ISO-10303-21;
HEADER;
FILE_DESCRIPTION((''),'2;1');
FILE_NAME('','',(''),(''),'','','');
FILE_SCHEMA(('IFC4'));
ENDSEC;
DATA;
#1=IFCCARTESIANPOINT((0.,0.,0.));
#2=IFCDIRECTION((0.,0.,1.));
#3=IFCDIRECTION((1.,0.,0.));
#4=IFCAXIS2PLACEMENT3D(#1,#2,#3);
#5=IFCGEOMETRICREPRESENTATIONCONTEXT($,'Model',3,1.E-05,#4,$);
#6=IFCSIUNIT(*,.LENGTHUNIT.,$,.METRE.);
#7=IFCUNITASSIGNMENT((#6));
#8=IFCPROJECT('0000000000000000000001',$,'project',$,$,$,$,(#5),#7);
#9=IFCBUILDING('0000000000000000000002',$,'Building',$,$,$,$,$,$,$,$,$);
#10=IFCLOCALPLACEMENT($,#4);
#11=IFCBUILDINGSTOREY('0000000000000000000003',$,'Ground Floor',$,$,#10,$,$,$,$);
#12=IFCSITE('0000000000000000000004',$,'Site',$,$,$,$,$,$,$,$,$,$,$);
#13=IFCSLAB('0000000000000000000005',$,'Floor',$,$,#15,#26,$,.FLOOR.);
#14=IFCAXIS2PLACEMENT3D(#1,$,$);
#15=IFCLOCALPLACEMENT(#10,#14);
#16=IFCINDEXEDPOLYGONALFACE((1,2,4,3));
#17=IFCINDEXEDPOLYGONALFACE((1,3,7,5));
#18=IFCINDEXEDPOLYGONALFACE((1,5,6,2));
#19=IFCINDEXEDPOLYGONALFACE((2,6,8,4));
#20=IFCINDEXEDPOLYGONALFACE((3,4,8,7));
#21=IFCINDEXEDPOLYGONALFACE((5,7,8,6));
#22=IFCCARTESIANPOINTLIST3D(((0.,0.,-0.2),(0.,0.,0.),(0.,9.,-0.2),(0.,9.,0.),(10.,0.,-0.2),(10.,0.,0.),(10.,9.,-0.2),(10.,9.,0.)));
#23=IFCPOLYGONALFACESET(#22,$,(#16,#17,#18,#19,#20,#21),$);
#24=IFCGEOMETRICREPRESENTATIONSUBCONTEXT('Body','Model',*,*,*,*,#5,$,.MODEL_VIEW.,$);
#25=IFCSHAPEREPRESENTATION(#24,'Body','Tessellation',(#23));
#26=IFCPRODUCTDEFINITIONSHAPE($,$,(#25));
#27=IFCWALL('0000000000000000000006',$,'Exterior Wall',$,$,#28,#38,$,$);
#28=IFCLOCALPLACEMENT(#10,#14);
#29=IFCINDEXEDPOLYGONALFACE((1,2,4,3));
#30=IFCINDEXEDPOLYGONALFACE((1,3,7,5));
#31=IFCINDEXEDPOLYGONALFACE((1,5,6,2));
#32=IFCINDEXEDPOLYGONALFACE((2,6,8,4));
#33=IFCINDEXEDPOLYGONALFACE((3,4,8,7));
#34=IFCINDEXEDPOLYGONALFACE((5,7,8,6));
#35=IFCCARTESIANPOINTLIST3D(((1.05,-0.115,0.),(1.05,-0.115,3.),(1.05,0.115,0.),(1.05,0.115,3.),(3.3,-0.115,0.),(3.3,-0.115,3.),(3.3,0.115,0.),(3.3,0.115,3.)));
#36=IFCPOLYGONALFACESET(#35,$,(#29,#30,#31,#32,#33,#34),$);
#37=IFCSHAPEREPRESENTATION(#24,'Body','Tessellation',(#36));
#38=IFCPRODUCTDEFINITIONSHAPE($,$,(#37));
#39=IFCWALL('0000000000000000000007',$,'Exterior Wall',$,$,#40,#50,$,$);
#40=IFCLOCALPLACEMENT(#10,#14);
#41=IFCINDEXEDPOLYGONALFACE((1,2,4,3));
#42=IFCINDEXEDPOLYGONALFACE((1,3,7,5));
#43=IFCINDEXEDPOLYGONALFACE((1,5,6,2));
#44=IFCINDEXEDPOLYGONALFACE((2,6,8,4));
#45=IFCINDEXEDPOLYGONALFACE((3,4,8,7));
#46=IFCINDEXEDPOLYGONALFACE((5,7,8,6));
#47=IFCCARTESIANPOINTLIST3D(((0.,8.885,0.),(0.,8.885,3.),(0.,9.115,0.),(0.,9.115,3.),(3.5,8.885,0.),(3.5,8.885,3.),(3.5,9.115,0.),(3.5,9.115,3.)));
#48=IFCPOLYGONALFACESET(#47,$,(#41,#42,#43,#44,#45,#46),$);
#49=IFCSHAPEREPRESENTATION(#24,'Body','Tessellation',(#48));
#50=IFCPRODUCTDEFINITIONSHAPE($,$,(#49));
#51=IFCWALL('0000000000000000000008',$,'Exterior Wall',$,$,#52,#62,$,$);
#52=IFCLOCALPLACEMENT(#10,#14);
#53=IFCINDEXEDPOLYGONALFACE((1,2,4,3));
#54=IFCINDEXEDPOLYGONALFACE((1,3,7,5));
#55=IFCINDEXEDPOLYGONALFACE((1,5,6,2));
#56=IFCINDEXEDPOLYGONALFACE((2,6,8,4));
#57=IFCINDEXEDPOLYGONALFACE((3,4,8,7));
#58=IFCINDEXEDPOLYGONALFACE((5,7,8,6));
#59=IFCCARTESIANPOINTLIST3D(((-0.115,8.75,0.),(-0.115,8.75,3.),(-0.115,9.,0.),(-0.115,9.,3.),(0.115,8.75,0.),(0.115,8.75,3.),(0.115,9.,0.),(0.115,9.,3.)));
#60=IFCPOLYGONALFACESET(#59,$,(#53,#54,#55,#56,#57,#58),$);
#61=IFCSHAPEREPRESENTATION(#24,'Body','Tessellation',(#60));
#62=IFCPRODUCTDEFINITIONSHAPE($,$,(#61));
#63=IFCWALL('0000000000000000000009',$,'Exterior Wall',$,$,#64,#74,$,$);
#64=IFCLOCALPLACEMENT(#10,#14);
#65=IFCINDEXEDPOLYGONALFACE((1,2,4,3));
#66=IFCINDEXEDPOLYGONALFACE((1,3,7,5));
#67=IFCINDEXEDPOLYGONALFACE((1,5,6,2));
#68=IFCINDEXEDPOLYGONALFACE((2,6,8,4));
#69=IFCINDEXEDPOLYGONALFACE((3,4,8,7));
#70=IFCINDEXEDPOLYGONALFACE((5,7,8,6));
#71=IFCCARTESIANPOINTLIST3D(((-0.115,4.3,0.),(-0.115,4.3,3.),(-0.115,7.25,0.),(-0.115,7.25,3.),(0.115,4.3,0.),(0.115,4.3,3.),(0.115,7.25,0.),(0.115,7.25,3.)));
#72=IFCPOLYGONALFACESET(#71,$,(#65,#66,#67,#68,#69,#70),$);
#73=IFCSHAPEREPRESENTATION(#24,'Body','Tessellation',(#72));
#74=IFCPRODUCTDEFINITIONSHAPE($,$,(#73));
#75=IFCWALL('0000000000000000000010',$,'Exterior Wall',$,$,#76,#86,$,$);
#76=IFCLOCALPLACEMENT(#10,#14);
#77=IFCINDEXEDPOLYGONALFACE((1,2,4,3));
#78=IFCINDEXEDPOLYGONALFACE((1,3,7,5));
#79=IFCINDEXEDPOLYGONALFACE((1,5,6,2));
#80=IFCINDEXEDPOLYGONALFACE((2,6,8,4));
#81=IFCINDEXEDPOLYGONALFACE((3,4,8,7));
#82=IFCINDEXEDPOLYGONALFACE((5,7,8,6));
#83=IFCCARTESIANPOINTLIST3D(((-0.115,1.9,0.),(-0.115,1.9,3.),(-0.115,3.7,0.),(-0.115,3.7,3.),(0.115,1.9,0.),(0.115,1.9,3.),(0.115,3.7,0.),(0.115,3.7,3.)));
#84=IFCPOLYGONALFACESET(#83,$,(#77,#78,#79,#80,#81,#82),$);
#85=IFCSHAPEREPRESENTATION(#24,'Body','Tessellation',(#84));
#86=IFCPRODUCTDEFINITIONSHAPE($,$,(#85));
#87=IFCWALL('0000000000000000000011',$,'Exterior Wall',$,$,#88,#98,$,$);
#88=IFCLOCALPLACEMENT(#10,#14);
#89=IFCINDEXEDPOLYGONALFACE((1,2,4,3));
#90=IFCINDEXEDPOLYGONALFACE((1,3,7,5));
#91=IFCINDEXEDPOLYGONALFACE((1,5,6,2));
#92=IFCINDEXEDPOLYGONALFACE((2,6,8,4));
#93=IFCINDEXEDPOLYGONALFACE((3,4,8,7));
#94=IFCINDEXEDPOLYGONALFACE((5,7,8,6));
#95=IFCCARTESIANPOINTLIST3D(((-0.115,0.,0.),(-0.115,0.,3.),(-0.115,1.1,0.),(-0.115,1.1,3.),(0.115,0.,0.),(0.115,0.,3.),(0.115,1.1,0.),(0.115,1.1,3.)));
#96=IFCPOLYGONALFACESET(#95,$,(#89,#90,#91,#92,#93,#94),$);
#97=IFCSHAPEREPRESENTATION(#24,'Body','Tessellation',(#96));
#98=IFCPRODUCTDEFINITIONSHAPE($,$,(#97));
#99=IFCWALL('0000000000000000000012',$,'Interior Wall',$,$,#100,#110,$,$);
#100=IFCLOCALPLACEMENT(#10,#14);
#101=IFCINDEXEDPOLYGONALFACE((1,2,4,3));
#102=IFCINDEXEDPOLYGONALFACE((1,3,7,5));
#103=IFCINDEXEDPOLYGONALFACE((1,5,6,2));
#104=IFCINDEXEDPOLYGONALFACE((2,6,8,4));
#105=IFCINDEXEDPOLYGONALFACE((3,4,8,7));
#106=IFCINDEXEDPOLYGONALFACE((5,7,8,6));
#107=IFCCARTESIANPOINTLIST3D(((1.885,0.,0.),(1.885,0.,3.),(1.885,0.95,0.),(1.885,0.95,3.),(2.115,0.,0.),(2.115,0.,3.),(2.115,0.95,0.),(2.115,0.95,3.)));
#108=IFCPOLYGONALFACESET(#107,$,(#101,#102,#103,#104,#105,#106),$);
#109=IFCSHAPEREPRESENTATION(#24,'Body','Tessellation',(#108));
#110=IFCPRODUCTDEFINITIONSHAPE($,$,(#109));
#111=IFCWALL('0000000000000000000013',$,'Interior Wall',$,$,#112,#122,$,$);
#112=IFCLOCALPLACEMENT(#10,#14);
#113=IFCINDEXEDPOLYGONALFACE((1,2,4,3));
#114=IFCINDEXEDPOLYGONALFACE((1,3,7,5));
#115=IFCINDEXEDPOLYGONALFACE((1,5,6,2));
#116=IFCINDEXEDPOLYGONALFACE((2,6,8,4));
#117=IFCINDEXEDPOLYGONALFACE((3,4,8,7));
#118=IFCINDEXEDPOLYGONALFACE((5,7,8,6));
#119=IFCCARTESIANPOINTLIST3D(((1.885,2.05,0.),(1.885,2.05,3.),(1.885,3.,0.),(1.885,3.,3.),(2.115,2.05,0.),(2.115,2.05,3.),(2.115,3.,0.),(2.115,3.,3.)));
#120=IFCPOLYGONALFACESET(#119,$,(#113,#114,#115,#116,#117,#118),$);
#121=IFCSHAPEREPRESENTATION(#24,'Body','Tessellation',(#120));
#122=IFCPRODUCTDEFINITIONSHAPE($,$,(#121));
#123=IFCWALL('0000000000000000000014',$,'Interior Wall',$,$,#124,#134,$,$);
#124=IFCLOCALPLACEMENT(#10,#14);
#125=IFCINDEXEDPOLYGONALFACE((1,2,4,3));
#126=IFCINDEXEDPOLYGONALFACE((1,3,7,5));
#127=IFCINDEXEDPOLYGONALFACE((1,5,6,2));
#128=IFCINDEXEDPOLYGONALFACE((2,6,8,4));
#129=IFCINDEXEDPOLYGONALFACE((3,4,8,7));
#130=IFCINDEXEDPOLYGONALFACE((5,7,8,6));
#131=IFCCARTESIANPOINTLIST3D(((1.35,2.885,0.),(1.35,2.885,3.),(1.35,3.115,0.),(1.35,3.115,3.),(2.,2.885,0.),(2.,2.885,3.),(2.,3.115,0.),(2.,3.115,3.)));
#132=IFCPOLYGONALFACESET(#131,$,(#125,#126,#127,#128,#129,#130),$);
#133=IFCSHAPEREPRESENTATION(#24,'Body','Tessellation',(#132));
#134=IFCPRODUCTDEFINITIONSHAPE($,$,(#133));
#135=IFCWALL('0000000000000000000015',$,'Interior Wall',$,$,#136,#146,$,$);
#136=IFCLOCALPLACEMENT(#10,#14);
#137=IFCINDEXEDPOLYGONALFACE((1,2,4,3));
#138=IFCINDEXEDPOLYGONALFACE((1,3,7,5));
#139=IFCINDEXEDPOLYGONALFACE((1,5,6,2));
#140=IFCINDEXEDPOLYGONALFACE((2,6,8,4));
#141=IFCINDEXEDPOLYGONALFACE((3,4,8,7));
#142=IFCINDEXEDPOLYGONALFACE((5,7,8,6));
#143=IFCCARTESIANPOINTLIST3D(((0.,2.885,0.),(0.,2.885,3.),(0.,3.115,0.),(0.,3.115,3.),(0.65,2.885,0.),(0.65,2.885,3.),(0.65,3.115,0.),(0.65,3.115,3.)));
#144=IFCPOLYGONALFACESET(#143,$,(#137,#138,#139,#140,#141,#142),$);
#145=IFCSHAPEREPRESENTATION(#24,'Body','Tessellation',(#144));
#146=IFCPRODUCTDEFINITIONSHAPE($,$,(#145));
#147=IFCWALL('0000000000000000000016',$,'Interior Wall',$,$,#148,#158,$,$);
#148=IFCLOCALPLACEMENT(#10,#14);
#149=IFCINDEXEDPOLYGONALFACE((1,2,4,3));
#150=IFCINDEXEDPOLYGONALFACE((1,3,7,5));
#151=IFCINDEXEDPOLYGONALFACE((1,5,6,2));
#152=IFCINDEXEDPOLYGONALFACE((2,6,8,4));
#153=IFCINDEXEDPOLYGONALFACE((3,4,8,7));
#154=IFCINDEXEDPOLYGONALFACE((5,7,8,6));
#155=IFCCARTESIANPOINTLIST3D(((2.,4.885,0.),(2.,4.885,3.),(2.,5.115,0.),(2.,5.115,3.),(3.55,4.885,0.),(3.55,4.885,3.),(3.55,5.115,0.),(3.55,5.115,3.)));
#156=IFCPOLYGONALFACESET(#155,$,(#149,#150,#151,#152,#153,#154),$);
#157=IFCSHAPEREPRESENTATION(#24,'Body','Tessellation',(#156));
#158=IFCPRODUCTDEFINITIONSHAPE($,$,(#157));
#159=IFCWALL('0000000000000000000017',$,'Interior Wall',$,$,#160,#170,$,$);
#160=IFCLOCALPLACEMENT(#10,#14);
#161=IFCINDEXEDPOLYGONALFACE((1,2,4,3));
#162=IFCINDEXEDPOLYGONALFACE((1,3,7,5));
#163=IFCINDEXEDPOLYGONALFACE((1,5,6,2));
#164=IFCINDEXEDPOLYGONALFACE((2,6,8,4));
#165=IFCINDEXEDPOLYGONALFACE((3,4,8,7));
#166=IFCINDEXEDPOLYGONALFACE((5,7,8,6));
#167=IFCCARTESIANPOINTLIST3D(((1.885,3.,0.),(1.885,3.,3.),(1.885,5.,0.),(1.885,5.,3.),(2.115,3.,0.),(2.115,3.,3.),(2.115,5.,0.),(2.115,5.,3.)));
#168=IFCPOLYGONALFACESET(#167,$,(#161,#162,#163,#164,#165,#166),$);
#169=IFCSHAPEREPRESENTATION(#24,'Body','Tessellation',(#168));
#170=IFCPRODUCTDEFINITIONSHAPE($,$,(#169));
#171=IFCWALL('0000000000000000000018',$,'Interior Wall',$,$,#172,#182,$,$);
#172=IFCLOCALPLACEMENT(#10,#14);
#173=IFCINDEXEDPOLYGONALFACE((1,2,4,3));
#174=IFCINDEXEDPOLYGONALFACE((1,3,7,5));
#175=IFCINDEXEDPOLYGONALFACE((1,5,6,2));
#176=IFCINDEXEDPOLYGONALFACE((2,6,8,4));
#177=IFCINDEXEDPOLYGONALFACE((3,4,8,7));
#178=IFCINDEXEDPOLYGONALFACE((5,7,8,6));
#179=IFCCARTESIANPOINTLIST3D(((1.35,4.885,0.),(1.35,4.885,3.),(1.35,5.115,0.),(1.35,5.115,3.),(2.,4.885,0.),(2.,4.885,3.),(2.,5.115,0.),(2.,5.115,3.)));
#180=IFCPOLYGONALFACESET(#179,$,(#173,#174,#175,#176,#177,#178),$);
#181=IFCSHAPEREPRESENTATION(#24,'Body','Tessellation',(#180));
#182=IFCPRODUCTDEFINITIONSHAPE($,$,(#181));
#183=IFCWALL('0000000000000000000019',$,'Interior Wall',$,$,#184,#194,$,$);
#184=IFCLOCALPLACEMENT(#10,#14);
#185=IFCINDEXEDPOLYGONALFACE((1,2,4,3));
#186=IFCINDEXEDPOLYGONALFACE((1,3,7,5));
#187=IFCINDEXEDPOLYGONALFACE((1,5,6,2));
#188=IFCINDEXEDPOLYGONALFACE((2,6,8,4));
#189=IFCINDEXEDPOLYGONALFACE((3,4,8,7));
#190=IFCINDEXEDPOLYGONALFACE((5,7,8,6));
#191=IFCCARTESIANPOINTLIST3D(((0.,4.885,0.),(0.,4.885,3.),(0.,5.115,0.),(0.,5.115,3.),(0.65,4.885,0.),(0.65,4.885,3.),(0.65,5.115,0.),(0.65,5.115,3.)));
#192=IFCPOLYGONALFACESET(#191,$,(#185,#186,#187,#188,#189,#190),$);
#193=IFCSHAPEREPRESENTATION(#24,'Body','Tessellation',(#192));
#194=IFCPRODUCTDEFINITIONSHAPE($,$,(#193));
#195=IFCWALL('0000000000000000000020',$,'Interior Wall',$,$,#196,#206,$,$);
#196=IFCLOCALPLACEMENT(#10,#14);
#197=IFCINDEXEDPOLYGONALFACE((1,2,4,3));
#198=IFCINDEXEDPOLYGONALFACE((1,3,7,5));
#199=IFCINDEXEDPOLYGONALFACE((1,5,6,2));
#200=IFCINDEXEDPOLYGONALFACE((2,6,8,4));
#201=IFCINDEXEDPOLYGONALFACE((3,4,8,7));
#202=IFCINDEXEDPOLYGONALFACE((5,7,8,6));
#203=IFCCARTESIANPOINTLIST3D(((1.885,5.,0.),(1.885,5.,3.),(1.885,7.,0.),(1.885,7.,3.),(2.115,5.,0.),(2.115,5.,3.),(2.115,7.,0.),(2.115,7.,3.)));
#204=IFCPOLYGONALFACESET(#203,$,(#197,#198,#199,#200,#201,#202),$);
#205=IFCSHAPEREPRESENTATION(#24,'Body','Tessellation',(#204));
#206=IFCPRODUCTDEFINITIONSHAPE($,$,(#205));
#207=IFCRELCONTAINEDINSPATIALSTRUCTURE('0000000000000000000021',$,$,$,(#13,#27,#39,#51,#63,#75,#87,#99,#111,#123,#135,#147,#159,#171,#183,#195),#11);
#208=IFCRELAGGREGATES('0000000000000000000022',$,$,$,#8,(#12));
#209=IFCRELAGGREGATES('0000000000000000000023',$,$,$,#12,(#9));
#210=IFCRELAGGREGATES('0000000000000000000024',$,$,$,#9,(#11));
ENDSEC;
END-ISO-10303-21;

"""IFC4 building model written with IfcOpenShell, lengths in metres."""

from ifc_helpers import new_model, si_unit, frame, origin_with_axes, place, context, subcontext, project, spatial, indexed_curve, outline, extrude, element, save


model = new_model("IFC4")

# Units and contexts
model_context = context("Model", 3, precision=1e-05, world=origin_with_axes())
body_context = subcontext(model_context, "Body", "Model", "MODEL_VIEW")
ifc_project = project(units=[si_unit("LENGTHUNIT", "METRE")], contexts=[model_context])

# Site, building, storey
site = spatial("IfcSite", under=ifc_project, Name="Site")
building = spatial("IfcBuilding", under=site, Name="Building")
storey_placement = place(None, origin_with_axes())
storey = spatial("IfcBuildingStorey", under=building, at=storey_placement, Name="Ground Floor")

# Slab
slab_placement = place(storey_placement, frame((0.0, 0.0, -0.2), z_axis=(0.0, 0.0, 1.0), x_axis=(1.0, 0.0, 0.0)))
element("IfcSlab", 1, at=slab_placement, inside=storey, Name="Floor", PredefinedType="FLOOR", context=body_context, shape_type="SweptSolid", body=[
    extrude(outline(indexed_curve([(0.0, 0.0), (10.0, 0.0), (10.0, 9.0), (0.0, 9.0)])), None, (0.0, 0.0, 1.0), 0.2),
])

# Walls
wall_1_placement = place(storey_placement, frame((1.05, 0.0, 0.0), z_axis=(0.0, 0.0, 1.0), x_axis=(1.0, 0.0, 0.0)))
element("IfcWall", 2, at=wall_1_placement, inside=storey, Name="Exterior Wall", context=body_context, shape_type="SweptSolid", body=[
    extrude(outline(indexed_curve([(0.0, 0.0), (0.0, 0.23), (2.25, 0.23), (2.25, 0.0), (0.0, 0.0)], self_intersect=False)), frame((0.0, -0.115, 0.0), z_axis=(0.0, 0.0, 1.0), x_axis=(1.0, 0.0, 0.0)), (0.0, 0.0, 1.0), 3.0),
])
wall_2_placement = place(storey_placement, frame((3.5, 9.0, 0.0), z_axis=(0.0, 0.0, 1.0), x_axis=(-1.0, 0.0, 0.0)))
element("IfcWall", 3, at=wall_2_placement, inside=storey, Name="Exterior Wall", context=body_context, shape_type="SweptSolid", body=[
    extrude(outline(indexed_curve([(0.0, 0.0), (0.0, 0.23), (3.5, 0.23), (3.5, 0.0), (0.0, 0.0)], self_intersect=False)), frame((0.0, -0.115, 0.0), z_axis=(0.0, 0.0, 1.0), x_axis=(1.0, 0.0, 0.0)), (0.0, 0.0, 1.0), 3.0),
])
wall_3_placement = place(storey_placement, frame((0.0, 9.0, 0.0), z_axis=(0.0, 0.0, 1.0), x_axis=(0.0, -1.0, 0.0)))
element("IfcWall", 4, at=wall_3_placement, inside=storey, Name="Exterior Wall", context=body_context, shape_type="SweptSolid", body=[
    extrude(outline(indexed_curve([(0.0, 0.0), (0.0, 0.23), (0.25, 0.23), (0.25, 0.0), (0.0, 0.0)], self_intersect=False)), frame((0.0, -0.115, 0.0), z_axis=(0.0, 0.0, 1.0), x_axis=(1.0, 0.0, 0.0)), (0.0, 0.0, 1.0), 3.0),
])
wall_4_placement = place(storey_placement, frame((0.0, 7.25, 0.0), z_axis=(0.0, 0.0, 1.0), x_axis=(0.0, -1.0, 0.0)))
element("IfcWall", 5, at=wall_4_placement, inside=storey, Name="Exterior Wall", context=body_context, shape_type="SweptSolid", body=[
    extrude(outline(indexed_curve([(0.0, 0.0), (0.0, 0.23), (2.95, 0.23), (2.95, 0.0), (0.0, 0.0)], self_intersect=False)), frame((0.0, -0.115, 0.0), z_axis=(0.0, 0.0, 1.0), x_axis=(1.0, 0.0, 0.0)), (0.0, 0.0, 1.0), 3.0),
])
wall_5_placement = place(storey_placement, frame((0.0, 3.7, 0.0), z_axis=(0.0, 0.0, 1.0), x_axis=(0.0, -1.0, 0.0)))
element("IfcWall", 6, at=wall_5_placement, inside=storey, Name="Exterior Wall", context=body_context, shape_type="SweptSolid", body=[
    extrude(outline(indexed_curve([(0.0, 0.0), (0.0, 0.23), (1.8, 0.23), (1.8, 0.0), (0.0, 0.0)], self_intersect=False)), frame((0.0, -0.115, 0.0), z_axis=(0.0, 0.0, 1.0), x_axis=(1.0, 0.0, 0.0)), (0.0, 0.0, 1.0), 3.0),
])
wall_6_placement = place(storey_placement, frame((0.0, 1.1, 0.0), z_axis=(0.0, 0.0, 1.0), x_axis=(0.0, -1.0, 0.0)))
element("IfcWall", 7, at=wall_6_placement, inside=storey, Name="Exterior Wall", context=body_context, shape_type="SweptSolid", body=[
    extrude(outline(indexed_curve([(0.0, 0.0), (0.0, 0.23), (1.1, 0.23), (1.1, 0.0), (0.0, 0.0)], self_intersect=False)), frame((0.0, -0.115, 0.0), z_axis=(0.0, 0.0, 1.0), x_axis=(1.0, 0.0, 0.0)), (0.0, 0.0, 1.0), 3.0),
])
wall_7_placement = place(storey_placement, frame((2.0, 0.0, 0.0), z_axis=(0.0, 0.0, 1.0), x_axis=(0.0, 1.0, 0.0)))
element("IfcWall", 8, at=wall_7_placement, inside=storey, Name="Interior Wall", context=body_context, shape_type="SweptSolid", body=[
    extrude(outline(indexed_curve([(0.0, 0.0), (0.0, 0.23), (0.95, 0.23), (0.95, 0.0), (0.0, 0.0)], self_intersect=False)), frame((0.0, -0.115, 0.0), z_axis=(0.0, 0.0, 1.0), x_axis=(1.0, 0.0, 0.0)), (0.0, 0.0, 1.0), 3.0),
])
wall_8_placement = place(storey_placement, frame((2.0, 2.05, 0.0), z_axis=(0.0, 0.0, 1.0), x_axis=(0.0, 1.0, 0.0)))
element("IfcWall", 9, at=wall_8_placement, inside=storey, Name="Interior Wall", context=body_context, shape_type="SweptSolid", body=[
    extrude(outline(indexed_curve([(0.0, 0.0), (0.0, 0.23), (0.95, 0.23), (0.95, 0.0), (0.0, 0.0)], self_intersect=False)), frame((0.0, -0.115, 0.0), z_axis=(0.0, 0.0, 1.0), x_axis=(1.0, 0.0, 0.0)), (0.0, 0.0, 1.0), 3.0),
])
for number, where, z_axis, x_axis, name in (
    (10, (2.0, 3.0, 0.0), (0.0, 0.0, 1.0), (-1.0, 0.0, 0.0), "Interior Wall"),
    (11, (0.65, 3.0, 0.0), (0.0, 0.0, 1.0), (-1.0, 0.0, 0.0), "Interior Wall"),
):
    element("IfcWall", number, at=place(storey_placement, frame(where, z_axis=z_axis, x_axis=x_axis)), inside=storey, Name=name, context=body_context, shape_type="SweptSolid", body=[
        extrude(outline(indexed_curve([(0.0, 0.0), (0.0, 0.23), (0.65, 0.23), (0.65, 0.0), (0.0, 0.0)], self_intersect=False)), frame((0.0, -0.115, 0.0), z_axis=(0.0, 0.0, 1.0), x_axis=(1.0, 0.0, 0.0)), (0.0, 0.0, 1.0), 3.0),
    ])
wall_9_placement = place(storey_placement, frame((3.55, 5.0, 0.0), z_axis=(0.0, 0.0, 1.0), x_axis=(-1.0, 0.0, 0.0)))
element("IfcWall", 12, at=wall_9_placement, inside=storey, Name="Interior Wall", context=body_context, shape_type="SweptSolid", body=[
    extrude(outline(indexed_curve([(0.0, 0.0), (0.0, 0.23), (1.55, 0.23), (1.55, 0.0), (0.0, 0.0)], self_intersect=False)), frame((0.0, -0.115, 0.0), z_axis=(0.0, 0.0, 1.0), x_axis=(1.0, 0.0, 0.0)), (0.0, 0.0, 1.0), 3.0),
])
wall_10_placement = place(storey_placement, frame((2.0, 5.0, 0.0), z_axis=(0.0, 0.0, 1.0), x_axis=(0.0, -1.0, 0.0)))
element("IfcWall", 13, at=wall_10_placement, inside=storey, Name="Interior Wall", context=body_context, shape_type="SweptSolid", body=[
    extrude(outline(indexed_curve([(0.0, 0.0), (0.0, 0.23), (2.0, 0.23), (2.0, 0.0), (0.0, 0.0)], self_intersect=False)), frame((0.0, -0.115, 0.0), z_axis=(0.0, 0.0, 1.0), x_axis=(1.0, 0.0, 0.0)), (0.0, 0.0, 1.0), 3.0),
])
for number, where, z_axis, x_axis, name in (
    (14, (2.0, 5.0, 0.0), (0.0, 0.0, 1.0), (-1.0, 0.0, 0.0), "Interior Wall"),
    (15, (0.65, 5.0, 0.0), (0.0, 0.0, 1.0), (-1.0, 0.0, 0.0), "Interior Wall"),
):
    element("IfcWall", number, at=place(storey_placement, frame(where, z_axis=z_axis, x_axis=x_axis)), inside=storey, Name=name, context=body_context, shape_type="SweptSolid", body=[
        extrude(outline(indexed_curve([(0.0, 0.0), (0.0, 0.23), (0.65, 0.23), (0.65, 0.0), (0.0, 0.0)], self_intersect=False)), frame((0.0, -0.115, 0.0), z_axis=(0.0, 0.0, 1.0), x_axis=(1.0, 0.0, 0.0)), (0.0, 0.0, 1.0), 3.0),
    ])
wall_11_placement = place(storey_placement, frame((2.0, 5.0, 0.0), z_axis=(0.0, 0.0, 1.0), x_axis=(0.0, 1.0, 0.0)))
element("IfcWall", 16, at=wall_11_placement, inside=storey, Name="Interior Wall", context=body_context, shape_type="SweptSolid", body=[
    extrude(outline(indexed_curve([(0.0, 0.0), (0.0, 0.23), (2.0, 0.23), (2.0, 0.0), (0.0, 0.0)], self_intersect=False)), frame((0.0, -0.115, 0.0), z_axis=(0.0, 0.0, 1.0), x_axis=(1.0, 0.0, 0.0)), (0.0, 0.0, 1.0), 3.0),
])

save(model, "model.ifc")
